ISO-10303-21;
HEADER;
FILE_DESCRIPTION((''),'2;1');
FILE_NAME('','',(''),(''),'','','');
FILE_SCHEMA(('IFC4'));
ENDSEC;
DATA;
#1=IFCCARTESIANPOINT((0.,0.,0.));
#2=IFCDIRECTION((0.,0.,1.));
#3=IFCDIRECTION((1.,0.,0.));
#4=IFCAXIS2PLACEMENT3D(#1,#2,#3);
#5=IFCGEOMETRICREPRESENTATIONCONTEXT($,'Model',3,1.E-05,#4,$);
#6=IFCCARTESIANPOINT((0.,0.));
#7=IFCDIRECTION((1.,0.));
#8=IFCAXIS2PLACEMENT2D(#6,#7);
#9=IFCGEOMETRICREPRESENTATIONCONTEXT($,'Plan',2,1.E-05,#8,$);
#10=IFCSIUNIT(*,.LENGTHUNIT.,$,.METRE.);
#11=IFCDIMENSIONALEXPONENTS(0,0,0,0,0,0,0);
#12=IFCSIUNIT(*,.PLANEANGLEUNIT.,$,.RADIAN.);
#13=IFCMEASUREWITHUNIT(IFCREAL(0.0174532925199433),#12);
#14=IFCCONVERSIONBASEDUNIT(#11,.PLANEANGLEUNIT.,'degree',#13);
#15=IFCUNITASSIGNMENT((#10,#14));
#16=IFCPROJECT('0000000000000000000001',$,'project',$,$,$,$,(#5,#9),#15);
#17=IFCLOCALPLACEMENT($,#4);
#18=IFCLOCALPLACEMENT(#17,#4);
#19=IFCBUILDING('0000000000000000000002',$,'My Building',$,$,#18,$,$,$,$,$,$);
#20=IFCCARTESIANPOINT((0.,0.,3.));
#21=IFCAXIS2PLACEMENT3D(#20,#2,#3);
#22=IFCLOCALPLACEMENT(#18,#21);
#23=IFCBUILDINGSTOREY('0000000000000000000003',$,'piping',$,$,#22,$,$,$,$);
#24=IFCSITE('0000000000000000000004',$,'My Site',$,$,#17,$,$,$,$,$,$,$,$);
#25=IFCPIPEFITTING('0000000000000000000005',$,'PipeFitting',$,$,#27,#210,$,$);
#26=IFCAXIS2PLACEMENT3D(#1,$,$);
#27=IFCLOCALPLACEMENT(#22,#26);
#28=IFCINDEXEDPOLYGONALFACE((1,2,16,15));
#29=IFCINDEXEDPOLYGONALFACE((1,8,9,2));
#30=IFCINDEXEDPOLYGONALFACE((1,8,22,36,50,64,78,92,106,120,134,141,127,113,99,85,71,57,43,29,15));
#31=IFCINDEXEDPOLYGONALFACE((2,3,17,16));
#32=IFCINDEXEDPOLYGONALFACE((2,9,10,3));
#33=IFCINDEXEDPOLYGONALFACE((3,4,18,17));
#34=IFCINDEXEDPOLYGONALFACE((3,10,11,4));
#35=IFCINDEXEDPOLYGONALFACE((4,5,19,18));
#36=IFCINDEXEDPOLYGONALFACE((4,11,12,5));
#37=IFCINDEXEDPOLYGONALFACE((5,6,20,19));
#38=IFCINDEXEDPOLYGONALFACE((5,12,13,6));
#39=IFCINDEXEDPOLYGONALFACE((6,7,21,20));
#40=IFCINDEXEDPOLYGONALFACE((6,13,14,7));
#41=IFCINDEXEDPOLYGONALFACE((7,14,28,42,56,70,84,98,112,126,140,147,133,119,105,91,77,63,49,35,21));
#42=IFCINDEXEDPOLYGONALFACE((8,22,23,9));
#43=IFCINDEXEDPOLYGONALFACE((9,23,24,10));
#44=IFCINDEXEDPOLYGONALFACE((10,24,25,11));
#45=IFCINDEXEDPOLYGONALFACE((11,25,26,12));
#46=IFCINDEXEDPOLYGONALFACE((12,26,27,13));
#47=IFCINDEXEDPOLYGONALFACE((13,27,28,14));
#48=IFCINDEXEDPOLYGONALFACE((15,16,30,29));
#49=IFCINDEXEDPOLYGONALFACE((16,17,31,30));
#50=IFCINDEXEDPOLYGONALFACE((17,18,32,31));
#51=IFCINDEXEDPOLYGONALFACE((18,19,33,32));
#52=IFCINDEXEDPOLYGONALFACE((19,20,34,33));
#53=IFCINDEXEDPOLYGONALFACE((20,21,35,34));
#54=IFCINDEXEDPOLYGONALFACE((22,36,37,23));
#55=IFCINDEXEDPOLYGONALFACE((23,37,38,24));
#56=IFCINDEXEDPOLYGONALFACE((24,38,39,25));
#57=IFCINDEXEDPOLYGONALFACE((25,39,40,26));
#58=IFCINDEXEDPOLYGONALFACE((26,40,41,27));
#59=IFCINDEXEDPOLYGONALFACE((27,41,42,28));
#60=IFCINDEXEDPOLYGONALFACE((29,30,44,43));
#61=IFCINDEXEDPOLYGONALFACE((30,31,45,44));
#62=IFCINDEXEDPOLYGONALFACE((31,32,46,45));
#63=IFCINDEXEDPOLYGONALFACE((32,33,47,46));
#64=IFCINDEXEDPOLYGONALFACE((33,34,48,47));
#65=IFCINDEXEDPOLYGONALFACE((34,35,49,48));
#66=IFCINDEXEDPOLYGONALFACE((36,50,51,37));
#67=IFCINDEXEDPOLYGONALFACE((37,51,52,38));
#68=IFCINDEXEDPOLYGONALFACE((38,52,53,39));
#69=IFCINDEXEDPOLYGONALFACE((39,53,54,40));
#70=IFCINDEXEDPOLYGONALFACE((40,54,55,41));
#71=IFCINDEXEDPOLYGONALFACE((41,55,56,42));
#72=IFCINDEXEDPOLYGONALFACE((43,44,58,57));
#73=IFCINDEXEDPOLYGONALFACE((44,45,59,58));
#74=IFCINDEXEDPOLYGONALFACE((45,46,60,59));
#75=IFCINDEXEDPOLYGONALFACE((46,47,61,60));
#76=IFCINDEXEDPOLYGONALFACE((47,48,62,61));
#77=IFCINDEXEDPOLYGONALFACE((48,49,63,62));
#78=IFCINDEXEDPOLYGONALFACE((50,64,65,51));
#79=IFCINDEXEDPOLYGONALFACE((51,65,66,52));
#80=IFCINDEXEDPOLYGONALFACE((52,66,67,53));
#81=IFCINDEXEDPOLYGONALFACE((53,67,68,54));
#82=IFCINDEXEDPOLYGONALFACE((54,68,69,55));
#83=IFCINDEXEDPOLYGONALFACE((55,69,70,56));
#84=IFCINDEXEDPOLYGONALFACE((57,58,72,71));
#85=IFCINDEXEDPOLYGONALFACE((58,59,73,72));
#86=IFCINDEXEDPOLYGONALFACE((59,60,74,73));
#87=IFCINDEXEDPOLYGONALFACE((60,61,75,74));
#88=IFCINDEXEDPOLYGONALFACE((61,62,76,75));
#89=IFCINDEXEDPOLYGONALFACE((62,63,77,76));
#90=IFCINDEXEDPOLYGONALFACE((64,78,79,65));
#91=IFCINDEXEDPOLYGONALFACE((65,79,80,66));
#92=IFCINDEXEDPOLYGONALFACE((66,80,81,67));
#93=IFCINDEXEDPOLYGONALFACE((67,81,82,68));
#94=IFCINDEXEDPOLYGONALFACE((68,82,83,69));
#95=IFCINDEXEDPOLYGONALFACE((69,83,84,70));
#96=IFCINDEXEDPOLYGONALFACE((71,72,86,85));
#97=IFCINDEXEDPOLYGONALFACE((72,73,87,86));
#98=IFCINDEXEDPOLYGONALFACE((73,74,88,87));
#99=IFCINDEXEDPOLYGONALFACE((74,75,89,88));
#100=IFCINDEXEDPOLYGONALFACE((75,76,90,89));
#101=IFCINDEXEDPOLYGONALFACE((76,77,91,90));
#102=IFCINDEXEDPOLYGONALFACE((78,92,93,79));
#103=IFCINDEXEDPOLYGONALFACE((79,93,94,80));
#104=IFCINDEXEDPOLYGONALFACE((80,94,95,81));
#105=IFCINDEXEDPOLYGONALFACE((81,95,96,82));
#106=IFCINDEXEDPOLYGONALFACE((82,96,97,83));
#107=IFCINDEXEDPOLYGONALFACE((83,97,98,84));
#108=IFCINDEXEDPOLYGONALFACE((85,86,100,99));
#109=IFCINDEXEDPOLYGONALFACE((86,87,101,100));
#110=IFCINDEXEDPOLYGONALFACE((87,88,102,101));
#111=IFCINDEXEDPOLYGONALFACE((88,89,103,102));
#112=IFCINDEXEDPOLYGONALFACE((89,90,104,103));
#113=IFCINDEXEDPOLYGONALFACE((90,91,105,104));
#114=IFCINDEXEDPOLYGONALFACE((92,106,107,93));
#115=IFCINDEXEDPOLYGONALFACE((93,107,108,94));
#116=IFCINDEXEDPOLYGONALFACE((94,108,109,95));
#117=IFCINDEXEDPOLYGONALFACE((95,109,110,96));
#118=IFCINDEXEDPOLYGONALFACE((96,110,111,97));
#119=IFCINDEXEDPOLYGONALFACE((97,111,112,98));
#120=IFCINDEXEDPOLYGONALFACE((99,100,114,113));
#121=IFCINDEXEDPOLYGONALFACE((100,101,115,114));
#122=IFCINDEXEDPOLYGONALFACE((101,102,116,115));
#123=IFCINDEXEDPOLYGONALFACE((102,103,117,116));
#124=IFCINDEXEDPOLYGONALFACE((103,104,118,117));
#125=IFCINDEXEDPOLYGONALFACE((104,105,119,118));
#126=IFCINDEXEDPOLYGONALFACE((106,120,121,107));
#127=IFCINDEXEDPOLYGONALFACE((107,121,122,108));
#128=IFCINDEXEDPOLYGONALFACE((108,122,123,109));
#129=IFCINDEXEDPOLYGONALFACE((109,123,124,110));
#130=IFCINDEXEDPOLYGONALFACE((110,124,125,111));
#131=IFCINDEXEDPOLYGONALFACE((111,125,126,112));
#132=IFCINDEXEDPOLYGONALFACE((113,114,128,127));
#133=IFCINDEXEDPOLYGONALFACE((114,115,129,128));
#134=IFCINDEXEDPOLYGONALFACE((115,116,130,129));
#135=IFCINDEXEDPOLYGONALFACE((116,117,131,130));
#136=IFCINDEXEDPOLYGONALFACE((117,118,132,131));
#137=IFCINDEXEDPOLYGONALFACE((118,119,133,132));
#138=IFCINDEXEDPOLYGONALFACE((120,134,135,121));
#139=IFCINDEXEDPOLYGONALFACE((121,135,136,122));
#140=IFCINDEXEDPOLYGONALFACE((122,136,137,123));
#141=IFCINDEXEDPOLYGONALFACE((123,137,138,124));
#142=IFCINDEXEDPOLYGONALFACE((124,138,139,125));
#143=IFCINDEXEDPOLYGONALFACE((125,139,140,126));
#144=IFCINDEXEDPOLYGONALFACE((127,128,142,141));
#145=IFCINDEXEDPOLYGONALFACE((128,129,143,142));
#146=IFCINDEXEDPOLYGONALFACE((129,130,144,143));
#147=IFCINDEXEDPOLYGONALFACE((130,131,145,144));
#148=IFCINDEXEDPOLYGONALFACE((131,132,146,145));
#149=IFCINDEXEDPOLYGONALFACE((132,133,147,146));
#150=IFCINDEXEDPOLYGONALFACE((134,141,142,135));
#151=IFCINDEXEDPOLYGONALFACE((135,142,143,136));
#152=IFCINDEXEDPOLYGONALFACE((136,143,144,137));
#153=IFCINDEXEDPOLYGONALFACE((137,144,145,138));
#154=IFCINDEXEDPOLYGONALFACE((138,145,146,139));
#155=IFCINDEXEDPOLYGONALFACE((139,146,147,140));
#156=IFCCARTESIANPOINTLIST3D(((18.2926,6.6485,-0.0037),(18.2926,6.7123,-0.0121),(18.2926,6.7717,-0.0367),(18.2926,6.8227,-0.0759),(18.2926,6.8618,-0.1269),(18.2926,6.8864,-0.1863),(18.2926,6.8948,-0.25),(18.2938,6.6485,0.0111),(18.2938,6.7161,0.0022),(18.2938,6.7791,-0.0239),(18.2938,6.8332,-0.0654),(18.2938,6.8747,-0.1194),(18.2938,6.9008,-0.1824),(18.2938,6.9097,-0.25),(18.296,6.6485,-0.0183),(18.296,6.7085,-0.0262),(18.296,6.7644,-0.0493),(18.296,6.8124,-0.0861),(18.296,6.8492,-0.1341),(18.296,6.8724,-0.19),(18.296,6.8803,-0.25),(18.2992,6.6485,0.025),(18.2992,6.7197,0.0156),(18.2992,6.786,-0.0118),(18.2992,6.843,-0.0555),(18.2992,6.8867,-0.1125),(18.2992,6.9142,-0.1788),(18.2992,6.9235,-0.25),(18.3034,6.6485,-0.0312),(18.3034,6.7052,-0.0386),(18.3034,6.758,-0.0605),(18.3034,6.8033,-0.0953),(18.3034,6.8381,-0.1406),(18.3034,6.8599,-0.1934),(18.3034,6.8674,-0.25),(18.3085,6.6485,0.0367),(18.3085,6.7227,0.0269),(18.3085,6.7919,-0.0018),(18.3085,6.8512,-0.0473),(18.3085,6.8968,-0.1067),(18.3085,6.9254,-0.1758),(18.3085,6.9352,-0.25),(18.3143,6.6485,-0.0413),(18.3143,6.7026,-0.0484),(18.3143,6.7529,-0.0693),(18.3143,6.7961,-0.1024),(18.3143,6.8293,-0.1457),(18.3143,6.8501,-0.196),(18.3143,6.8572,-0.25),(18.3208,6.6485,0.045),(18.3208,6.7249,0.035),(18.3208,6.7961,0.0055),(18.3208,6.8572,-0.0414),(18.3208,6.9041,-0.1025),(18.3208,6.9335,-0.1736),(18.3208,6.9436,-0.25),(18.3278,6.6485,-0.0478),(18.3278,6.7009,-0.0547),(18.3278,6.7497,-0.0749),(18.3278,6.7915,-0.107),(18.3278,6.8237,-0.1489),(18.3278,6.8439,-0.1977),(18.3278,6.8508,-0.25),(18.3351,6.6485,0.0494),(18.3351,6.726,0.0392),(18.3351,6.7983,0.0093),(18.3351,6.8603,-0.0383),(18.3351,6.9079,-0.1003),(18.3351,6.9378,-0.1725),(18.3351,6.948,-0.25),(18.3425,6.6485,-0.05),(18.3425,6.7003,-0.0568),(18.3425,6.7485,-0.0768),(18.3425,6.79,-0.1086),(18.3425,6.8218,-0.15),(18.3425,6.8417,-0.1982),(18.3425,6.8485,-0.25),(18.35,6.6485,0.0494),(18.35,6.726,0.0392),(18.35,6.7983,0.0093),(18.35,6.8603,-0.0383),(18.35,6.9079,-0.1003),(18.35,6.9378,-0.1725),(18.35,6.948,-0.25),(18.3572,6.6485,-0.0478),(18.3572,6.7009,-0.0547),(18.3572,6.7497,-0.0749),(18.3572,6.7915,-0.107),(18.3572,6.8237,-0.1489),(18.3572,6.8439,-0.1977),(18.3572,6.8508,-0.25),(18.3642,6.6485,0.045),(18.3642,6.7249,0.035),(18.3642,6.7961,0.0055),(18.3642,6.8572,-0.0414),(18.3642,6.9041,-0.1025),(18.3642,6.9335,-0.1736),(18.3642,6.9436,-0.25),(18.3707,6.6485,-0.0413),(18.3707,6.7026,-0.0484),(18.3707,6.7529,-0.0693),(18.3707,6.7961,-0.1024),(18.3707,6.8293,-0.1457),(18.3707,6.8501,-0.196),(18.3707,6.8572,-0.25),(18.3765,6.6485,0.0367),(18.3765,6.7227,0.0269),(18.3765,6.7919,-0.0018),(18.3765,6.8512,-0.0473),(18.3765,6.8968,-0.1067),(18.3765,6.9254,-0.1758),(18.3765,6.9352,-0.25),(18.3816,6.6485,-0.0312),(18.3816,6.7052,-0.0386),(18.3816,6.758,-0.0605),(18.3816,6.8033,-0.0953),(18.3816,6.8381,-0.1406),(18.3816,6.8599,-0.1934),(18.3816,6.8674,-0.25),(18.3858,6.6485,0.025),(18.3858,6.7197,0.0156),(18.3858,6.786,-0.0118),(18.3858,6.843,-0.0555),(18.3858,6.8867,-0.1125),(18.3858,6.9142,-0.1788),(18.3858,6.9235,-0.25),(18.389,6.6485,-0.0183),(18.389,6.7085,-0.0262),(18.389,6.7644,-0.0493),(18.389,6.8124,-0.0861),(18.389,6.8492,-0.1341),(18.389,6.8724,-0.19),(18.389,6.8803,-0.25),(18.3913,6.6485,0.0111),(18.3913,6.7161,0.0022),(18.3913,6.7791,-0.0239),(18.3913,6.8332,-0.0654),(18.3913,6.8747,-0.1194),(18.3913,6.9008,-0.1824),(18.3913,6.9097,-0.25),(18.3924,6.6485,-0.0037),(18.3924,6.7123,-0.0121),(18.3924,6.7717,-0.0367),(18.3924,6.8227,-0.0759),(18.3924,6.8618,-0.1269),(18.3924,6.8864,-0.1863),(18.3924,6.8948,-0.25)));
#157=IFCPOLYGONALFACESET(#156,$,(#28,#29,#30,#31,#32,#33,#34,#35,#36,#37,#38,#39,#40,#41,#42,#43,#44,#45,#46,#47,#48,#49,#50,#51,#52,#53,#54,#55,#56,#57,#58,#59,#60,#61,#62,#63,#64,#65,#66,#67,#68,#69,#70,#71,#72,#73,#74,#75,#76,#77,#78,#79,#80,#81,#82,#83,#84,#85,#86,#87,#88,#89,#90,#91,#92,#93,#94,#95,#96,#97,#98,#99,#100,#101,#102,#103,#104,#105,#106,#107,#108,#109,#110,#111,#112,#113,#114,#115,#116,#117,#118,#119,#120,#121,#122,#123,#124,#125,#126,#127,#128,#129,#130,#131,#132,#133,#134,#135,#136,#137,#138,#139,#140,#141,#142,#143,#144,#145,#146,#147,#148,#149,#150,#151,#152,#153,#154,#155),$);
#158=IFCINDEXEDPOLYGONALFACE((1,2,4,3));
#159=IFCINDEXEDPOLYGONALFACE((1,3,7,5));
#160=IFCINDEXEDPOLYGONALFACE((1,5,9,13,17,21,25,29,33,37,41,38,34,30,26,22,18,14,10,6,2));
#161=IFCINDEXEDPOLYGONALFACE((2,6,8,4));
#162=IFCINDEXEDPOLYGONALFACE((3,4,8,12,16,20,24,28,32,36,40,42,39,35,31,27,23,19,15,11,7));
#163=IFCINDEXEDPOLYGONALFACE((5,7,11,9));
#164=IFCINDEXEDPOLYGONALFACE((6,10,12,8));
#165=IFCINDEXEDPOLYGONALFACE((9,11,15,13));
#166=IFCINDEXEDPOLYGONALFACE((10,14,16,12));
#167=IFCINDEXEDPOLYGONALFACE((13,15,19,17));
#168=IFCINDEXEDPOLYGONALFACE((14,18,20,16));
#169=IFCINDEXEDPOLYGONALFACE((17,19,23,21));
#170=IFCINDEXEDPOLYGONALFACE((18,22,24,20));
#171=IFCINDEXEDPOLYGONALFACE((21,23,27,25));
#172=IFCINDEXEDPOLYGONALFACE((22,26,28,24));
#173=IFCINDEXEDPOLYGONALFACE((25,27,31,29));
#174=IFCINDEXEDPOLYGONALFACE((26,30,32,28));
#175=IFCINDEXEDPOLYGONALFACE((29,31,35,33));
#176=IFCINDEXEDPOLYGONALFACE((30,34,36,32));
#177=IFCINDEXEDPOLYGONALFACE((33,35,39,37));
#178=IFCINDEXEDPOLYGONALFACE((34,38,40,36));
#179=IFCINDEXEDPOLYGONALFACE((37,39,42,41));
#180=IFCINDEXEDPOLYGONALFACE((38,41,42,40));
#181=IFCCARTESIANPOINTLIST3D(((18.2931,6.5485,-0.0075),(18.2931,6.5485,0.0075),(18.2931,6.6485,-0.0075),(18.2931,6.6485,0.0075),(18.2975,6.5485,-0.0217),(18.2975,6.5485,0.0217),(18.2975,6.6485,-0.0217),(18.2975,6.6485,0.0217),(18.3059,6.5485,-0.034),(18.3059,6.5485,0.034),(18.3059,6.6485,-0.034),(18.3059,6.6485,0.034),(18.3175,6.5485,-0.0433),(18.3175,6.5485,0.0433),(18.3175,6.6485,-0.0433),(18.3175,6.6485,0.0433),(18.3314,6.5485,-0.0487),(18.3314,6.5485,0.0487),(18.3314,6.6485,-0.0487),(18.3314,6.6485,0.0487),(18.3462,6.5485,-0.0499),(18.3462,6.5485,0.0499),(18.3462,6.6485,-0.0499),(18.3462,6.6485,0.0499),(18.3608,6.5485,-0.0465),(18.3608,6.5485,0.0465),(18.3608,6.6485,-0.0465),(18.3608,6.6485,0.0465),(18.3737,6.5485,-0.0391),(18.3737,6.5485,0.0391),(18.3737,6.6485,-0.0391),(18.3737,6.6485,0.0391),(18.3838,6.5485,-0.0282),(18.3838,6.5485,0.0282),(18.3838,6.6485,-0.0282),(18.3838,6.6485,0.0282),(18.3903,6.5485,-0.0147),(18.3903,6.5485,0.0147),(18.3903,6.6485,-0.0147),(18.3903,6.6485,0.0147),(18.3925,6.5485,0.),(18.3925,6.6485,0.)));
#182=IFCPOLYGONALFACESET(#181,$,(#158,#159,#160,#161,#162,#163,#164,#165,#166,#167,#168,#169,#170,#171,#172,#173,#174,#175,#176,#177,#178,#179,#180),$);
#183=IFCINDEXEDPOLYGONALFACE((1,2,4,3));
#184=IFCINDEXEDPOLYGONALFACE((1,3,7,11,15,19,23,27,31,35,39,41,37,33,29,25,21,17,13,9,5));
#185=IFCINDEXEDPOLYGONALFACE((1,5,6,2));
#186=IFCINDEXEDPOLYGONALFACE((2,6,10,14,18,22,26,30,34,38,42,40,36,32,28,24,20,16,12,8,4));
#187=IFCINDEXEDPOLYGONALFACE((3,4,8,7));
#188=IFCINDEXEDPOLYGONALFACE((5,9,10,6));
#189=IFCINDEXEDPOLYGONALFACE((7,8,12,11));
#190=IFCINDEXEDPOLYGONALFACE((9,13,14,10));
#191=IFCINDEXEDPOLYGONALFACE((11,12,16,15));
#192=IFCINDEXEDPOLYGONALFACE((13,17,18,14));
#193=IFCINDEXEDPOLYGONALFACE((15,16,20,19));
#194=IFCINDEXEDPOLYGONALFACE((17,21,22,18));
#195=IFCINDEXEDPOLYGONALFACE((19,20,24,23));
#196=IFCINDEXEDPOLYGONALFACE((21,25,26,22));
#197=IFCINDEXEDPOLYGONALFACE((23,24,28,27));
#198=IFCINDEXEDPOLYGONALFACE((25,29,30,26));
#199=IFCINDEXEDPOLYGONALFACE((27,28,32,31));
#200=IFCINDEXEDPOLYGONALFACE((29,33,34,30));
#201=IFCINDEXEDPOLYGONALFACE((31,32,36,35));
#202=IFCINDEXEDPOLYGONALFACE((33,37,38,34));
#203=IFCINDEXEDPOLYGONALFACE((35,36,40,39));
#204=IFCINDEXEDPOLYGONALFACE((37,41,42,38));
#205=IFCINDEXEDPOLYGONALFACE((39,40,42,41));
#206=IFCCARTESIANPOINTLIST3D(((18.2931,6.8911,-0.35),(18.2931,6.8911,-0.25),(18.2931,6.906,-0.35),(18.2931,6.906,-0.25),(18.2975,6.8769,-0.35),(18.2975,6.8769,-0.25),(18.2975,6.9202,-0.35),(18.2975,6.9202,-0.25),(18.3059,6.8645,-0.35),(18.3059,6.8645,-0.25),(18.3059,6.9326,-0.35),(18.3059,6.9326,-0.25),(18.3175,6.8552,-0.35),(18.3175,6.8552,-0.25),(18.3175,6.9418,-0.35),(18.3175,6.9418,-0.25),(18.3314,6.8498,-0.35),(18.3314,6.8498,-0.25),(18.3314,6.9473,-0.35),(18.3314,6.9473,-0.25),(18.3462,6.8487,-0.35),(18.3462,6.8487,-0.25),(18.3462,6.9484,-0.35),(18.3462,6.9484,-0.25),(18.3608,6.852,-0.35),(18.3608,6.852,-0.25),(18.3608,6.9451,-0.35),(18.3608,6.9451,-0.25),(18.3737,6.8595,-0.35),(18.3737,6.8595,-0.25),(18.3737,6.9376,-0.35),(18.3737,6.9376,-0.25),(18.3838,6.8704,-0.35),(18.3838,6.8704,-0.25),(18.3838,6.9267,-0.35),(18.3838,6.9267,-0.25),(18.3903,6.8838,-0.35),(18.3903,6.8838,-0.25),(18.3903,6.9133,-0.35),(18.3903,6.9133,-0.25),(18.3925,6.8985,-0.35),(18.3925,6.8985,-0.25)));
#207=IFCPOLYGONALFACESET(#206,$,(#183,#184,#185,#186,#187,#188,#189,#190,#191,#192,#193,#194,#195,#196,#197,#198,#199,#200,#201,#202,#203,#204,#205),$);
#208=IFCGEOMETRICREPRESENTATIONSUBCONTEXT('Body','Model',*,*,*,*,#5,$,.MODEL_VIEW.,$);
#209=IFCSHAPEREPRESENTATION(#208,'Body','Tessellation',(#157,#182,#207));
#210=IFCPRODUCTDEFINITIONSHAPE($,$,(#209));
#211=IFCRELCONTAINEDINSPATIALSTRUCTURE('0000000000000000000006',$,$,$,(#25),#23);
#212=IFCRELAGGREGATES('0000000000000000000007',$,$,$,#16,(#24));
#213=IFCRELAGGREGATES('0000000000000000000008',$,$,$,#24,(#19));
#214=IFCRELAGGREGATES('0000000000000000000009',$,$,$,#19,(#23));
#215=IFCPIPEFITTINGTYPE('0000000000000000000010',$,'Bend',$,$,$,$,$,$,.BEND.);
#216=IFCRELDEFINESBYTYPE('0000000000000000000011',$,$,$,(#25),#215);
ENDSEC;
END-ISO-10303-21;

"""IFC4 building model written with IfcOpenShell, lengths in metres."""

from ifc_helpers import new_model, entity, si_unit, converted_unit, frame, origin_with_axes, origin_2d_with_axis, place, context, subcontext, project, spatial, circle, extrude, source, transform, mapped, type_object, type_shapes, element, save


model = new_model("IFC4")

# Units and contexts
model_context = context("Model", 3, precision=1e-05, world=origin_with_axes())
plan_context = context("Plan", 2, precision=1e-05, world=origin_2d_with_axis())
body_context = subcontext(model_context, "Body", "Model", "MODEL_VIEW")
ifc_project = project(units=[si_unit("LENGTHUNIT", "METRE"), converted_unit("PLANEANGLEUNIT", "degree", entity("IfcReal", 0.0174532925199433), si_unit("PLANEANGLEUNIT", "RADIAN"), dimensions=[0, 0, 0, 0, 0, 0, 0])], contexts=[model_context, plan_context])

# Site, building, storey
site_placement = place(None, origin_with_axes())
site = spatial("IfcSite", under=ifc_project, at=site_placement, Name="My Site")
building_placement = place(site_placement, origin_with_axes())
building = spatial("IfcBuilding", under=site, at=building_placement, Name="My Building")
storey_placement = place(building_placement, frame((0.0, 0.0, 3.0), z_axis=(0.0, 0.0, 1.0), x_axis=(1.0, 0.0, 0.0)))
storey = spatial("IfcBuildingStorey", under=building, at=storey_placement, Name="piping")

# Pipe fitting
pipe_fitting_type = type_object("IfcPipeFittingType", Name="Bend", PredefinedType="BEND")
shared_shape = source(origin_with_axes(), body_context, "Body", "SolidModel", [
    entity("IfcSweptDiskSolid", entity("IfcIndexedPolyCurve", entity("IfcCartesianPointList3D", [[0.0, 0.0, -0.1], [0.0, -0.0732, -0.2768], [0.0, -0.25, -0.35]]), [entity("IfcArcIndex", [1, 2, 3])]), 0.05),
    extrude(circle(Radius=0.05), origin_with_axes(), (0.0, 0.0, -1.0), 0.1),
    extrude(circle(Radius=0.05), frame((0.0, -0.25, -0.35), z_axis=(0.0, -1.0, 0.0), x_axis=(1.0, 0.0, 0.0)), (0.0, 0.0, 1.0), 0.1),
])
type_shapes(pipe_fitting_type, [shared_shape])
for number, where, z_axis, x_axis, name in (
    (1, (18.3425, 6.5485, 0.0), (0.0, -1.0, 0.0), (1.0, 0.0, 0.0), "PipeFitting"),
):
    element("IfcPipeFitting", number, at=place(storey_placement, frame(where, z_axis=z_axis, x_axis=x_axis)), inside=storey, type_object=pipe_fitting_type, Name=name, context=body_context, shape_type="MappedRepresentation", body=[
        mapped(shared_shape, transform((0.0, 0.0, 0.0), x_axis=(1.0, 0.0, 0.0), y_axis=(0.0, 1.0, 0.0), z_axis=(0.0, 0.0, 1.0), scale=1.0)),
    ])

save(model, "model.ifc")
